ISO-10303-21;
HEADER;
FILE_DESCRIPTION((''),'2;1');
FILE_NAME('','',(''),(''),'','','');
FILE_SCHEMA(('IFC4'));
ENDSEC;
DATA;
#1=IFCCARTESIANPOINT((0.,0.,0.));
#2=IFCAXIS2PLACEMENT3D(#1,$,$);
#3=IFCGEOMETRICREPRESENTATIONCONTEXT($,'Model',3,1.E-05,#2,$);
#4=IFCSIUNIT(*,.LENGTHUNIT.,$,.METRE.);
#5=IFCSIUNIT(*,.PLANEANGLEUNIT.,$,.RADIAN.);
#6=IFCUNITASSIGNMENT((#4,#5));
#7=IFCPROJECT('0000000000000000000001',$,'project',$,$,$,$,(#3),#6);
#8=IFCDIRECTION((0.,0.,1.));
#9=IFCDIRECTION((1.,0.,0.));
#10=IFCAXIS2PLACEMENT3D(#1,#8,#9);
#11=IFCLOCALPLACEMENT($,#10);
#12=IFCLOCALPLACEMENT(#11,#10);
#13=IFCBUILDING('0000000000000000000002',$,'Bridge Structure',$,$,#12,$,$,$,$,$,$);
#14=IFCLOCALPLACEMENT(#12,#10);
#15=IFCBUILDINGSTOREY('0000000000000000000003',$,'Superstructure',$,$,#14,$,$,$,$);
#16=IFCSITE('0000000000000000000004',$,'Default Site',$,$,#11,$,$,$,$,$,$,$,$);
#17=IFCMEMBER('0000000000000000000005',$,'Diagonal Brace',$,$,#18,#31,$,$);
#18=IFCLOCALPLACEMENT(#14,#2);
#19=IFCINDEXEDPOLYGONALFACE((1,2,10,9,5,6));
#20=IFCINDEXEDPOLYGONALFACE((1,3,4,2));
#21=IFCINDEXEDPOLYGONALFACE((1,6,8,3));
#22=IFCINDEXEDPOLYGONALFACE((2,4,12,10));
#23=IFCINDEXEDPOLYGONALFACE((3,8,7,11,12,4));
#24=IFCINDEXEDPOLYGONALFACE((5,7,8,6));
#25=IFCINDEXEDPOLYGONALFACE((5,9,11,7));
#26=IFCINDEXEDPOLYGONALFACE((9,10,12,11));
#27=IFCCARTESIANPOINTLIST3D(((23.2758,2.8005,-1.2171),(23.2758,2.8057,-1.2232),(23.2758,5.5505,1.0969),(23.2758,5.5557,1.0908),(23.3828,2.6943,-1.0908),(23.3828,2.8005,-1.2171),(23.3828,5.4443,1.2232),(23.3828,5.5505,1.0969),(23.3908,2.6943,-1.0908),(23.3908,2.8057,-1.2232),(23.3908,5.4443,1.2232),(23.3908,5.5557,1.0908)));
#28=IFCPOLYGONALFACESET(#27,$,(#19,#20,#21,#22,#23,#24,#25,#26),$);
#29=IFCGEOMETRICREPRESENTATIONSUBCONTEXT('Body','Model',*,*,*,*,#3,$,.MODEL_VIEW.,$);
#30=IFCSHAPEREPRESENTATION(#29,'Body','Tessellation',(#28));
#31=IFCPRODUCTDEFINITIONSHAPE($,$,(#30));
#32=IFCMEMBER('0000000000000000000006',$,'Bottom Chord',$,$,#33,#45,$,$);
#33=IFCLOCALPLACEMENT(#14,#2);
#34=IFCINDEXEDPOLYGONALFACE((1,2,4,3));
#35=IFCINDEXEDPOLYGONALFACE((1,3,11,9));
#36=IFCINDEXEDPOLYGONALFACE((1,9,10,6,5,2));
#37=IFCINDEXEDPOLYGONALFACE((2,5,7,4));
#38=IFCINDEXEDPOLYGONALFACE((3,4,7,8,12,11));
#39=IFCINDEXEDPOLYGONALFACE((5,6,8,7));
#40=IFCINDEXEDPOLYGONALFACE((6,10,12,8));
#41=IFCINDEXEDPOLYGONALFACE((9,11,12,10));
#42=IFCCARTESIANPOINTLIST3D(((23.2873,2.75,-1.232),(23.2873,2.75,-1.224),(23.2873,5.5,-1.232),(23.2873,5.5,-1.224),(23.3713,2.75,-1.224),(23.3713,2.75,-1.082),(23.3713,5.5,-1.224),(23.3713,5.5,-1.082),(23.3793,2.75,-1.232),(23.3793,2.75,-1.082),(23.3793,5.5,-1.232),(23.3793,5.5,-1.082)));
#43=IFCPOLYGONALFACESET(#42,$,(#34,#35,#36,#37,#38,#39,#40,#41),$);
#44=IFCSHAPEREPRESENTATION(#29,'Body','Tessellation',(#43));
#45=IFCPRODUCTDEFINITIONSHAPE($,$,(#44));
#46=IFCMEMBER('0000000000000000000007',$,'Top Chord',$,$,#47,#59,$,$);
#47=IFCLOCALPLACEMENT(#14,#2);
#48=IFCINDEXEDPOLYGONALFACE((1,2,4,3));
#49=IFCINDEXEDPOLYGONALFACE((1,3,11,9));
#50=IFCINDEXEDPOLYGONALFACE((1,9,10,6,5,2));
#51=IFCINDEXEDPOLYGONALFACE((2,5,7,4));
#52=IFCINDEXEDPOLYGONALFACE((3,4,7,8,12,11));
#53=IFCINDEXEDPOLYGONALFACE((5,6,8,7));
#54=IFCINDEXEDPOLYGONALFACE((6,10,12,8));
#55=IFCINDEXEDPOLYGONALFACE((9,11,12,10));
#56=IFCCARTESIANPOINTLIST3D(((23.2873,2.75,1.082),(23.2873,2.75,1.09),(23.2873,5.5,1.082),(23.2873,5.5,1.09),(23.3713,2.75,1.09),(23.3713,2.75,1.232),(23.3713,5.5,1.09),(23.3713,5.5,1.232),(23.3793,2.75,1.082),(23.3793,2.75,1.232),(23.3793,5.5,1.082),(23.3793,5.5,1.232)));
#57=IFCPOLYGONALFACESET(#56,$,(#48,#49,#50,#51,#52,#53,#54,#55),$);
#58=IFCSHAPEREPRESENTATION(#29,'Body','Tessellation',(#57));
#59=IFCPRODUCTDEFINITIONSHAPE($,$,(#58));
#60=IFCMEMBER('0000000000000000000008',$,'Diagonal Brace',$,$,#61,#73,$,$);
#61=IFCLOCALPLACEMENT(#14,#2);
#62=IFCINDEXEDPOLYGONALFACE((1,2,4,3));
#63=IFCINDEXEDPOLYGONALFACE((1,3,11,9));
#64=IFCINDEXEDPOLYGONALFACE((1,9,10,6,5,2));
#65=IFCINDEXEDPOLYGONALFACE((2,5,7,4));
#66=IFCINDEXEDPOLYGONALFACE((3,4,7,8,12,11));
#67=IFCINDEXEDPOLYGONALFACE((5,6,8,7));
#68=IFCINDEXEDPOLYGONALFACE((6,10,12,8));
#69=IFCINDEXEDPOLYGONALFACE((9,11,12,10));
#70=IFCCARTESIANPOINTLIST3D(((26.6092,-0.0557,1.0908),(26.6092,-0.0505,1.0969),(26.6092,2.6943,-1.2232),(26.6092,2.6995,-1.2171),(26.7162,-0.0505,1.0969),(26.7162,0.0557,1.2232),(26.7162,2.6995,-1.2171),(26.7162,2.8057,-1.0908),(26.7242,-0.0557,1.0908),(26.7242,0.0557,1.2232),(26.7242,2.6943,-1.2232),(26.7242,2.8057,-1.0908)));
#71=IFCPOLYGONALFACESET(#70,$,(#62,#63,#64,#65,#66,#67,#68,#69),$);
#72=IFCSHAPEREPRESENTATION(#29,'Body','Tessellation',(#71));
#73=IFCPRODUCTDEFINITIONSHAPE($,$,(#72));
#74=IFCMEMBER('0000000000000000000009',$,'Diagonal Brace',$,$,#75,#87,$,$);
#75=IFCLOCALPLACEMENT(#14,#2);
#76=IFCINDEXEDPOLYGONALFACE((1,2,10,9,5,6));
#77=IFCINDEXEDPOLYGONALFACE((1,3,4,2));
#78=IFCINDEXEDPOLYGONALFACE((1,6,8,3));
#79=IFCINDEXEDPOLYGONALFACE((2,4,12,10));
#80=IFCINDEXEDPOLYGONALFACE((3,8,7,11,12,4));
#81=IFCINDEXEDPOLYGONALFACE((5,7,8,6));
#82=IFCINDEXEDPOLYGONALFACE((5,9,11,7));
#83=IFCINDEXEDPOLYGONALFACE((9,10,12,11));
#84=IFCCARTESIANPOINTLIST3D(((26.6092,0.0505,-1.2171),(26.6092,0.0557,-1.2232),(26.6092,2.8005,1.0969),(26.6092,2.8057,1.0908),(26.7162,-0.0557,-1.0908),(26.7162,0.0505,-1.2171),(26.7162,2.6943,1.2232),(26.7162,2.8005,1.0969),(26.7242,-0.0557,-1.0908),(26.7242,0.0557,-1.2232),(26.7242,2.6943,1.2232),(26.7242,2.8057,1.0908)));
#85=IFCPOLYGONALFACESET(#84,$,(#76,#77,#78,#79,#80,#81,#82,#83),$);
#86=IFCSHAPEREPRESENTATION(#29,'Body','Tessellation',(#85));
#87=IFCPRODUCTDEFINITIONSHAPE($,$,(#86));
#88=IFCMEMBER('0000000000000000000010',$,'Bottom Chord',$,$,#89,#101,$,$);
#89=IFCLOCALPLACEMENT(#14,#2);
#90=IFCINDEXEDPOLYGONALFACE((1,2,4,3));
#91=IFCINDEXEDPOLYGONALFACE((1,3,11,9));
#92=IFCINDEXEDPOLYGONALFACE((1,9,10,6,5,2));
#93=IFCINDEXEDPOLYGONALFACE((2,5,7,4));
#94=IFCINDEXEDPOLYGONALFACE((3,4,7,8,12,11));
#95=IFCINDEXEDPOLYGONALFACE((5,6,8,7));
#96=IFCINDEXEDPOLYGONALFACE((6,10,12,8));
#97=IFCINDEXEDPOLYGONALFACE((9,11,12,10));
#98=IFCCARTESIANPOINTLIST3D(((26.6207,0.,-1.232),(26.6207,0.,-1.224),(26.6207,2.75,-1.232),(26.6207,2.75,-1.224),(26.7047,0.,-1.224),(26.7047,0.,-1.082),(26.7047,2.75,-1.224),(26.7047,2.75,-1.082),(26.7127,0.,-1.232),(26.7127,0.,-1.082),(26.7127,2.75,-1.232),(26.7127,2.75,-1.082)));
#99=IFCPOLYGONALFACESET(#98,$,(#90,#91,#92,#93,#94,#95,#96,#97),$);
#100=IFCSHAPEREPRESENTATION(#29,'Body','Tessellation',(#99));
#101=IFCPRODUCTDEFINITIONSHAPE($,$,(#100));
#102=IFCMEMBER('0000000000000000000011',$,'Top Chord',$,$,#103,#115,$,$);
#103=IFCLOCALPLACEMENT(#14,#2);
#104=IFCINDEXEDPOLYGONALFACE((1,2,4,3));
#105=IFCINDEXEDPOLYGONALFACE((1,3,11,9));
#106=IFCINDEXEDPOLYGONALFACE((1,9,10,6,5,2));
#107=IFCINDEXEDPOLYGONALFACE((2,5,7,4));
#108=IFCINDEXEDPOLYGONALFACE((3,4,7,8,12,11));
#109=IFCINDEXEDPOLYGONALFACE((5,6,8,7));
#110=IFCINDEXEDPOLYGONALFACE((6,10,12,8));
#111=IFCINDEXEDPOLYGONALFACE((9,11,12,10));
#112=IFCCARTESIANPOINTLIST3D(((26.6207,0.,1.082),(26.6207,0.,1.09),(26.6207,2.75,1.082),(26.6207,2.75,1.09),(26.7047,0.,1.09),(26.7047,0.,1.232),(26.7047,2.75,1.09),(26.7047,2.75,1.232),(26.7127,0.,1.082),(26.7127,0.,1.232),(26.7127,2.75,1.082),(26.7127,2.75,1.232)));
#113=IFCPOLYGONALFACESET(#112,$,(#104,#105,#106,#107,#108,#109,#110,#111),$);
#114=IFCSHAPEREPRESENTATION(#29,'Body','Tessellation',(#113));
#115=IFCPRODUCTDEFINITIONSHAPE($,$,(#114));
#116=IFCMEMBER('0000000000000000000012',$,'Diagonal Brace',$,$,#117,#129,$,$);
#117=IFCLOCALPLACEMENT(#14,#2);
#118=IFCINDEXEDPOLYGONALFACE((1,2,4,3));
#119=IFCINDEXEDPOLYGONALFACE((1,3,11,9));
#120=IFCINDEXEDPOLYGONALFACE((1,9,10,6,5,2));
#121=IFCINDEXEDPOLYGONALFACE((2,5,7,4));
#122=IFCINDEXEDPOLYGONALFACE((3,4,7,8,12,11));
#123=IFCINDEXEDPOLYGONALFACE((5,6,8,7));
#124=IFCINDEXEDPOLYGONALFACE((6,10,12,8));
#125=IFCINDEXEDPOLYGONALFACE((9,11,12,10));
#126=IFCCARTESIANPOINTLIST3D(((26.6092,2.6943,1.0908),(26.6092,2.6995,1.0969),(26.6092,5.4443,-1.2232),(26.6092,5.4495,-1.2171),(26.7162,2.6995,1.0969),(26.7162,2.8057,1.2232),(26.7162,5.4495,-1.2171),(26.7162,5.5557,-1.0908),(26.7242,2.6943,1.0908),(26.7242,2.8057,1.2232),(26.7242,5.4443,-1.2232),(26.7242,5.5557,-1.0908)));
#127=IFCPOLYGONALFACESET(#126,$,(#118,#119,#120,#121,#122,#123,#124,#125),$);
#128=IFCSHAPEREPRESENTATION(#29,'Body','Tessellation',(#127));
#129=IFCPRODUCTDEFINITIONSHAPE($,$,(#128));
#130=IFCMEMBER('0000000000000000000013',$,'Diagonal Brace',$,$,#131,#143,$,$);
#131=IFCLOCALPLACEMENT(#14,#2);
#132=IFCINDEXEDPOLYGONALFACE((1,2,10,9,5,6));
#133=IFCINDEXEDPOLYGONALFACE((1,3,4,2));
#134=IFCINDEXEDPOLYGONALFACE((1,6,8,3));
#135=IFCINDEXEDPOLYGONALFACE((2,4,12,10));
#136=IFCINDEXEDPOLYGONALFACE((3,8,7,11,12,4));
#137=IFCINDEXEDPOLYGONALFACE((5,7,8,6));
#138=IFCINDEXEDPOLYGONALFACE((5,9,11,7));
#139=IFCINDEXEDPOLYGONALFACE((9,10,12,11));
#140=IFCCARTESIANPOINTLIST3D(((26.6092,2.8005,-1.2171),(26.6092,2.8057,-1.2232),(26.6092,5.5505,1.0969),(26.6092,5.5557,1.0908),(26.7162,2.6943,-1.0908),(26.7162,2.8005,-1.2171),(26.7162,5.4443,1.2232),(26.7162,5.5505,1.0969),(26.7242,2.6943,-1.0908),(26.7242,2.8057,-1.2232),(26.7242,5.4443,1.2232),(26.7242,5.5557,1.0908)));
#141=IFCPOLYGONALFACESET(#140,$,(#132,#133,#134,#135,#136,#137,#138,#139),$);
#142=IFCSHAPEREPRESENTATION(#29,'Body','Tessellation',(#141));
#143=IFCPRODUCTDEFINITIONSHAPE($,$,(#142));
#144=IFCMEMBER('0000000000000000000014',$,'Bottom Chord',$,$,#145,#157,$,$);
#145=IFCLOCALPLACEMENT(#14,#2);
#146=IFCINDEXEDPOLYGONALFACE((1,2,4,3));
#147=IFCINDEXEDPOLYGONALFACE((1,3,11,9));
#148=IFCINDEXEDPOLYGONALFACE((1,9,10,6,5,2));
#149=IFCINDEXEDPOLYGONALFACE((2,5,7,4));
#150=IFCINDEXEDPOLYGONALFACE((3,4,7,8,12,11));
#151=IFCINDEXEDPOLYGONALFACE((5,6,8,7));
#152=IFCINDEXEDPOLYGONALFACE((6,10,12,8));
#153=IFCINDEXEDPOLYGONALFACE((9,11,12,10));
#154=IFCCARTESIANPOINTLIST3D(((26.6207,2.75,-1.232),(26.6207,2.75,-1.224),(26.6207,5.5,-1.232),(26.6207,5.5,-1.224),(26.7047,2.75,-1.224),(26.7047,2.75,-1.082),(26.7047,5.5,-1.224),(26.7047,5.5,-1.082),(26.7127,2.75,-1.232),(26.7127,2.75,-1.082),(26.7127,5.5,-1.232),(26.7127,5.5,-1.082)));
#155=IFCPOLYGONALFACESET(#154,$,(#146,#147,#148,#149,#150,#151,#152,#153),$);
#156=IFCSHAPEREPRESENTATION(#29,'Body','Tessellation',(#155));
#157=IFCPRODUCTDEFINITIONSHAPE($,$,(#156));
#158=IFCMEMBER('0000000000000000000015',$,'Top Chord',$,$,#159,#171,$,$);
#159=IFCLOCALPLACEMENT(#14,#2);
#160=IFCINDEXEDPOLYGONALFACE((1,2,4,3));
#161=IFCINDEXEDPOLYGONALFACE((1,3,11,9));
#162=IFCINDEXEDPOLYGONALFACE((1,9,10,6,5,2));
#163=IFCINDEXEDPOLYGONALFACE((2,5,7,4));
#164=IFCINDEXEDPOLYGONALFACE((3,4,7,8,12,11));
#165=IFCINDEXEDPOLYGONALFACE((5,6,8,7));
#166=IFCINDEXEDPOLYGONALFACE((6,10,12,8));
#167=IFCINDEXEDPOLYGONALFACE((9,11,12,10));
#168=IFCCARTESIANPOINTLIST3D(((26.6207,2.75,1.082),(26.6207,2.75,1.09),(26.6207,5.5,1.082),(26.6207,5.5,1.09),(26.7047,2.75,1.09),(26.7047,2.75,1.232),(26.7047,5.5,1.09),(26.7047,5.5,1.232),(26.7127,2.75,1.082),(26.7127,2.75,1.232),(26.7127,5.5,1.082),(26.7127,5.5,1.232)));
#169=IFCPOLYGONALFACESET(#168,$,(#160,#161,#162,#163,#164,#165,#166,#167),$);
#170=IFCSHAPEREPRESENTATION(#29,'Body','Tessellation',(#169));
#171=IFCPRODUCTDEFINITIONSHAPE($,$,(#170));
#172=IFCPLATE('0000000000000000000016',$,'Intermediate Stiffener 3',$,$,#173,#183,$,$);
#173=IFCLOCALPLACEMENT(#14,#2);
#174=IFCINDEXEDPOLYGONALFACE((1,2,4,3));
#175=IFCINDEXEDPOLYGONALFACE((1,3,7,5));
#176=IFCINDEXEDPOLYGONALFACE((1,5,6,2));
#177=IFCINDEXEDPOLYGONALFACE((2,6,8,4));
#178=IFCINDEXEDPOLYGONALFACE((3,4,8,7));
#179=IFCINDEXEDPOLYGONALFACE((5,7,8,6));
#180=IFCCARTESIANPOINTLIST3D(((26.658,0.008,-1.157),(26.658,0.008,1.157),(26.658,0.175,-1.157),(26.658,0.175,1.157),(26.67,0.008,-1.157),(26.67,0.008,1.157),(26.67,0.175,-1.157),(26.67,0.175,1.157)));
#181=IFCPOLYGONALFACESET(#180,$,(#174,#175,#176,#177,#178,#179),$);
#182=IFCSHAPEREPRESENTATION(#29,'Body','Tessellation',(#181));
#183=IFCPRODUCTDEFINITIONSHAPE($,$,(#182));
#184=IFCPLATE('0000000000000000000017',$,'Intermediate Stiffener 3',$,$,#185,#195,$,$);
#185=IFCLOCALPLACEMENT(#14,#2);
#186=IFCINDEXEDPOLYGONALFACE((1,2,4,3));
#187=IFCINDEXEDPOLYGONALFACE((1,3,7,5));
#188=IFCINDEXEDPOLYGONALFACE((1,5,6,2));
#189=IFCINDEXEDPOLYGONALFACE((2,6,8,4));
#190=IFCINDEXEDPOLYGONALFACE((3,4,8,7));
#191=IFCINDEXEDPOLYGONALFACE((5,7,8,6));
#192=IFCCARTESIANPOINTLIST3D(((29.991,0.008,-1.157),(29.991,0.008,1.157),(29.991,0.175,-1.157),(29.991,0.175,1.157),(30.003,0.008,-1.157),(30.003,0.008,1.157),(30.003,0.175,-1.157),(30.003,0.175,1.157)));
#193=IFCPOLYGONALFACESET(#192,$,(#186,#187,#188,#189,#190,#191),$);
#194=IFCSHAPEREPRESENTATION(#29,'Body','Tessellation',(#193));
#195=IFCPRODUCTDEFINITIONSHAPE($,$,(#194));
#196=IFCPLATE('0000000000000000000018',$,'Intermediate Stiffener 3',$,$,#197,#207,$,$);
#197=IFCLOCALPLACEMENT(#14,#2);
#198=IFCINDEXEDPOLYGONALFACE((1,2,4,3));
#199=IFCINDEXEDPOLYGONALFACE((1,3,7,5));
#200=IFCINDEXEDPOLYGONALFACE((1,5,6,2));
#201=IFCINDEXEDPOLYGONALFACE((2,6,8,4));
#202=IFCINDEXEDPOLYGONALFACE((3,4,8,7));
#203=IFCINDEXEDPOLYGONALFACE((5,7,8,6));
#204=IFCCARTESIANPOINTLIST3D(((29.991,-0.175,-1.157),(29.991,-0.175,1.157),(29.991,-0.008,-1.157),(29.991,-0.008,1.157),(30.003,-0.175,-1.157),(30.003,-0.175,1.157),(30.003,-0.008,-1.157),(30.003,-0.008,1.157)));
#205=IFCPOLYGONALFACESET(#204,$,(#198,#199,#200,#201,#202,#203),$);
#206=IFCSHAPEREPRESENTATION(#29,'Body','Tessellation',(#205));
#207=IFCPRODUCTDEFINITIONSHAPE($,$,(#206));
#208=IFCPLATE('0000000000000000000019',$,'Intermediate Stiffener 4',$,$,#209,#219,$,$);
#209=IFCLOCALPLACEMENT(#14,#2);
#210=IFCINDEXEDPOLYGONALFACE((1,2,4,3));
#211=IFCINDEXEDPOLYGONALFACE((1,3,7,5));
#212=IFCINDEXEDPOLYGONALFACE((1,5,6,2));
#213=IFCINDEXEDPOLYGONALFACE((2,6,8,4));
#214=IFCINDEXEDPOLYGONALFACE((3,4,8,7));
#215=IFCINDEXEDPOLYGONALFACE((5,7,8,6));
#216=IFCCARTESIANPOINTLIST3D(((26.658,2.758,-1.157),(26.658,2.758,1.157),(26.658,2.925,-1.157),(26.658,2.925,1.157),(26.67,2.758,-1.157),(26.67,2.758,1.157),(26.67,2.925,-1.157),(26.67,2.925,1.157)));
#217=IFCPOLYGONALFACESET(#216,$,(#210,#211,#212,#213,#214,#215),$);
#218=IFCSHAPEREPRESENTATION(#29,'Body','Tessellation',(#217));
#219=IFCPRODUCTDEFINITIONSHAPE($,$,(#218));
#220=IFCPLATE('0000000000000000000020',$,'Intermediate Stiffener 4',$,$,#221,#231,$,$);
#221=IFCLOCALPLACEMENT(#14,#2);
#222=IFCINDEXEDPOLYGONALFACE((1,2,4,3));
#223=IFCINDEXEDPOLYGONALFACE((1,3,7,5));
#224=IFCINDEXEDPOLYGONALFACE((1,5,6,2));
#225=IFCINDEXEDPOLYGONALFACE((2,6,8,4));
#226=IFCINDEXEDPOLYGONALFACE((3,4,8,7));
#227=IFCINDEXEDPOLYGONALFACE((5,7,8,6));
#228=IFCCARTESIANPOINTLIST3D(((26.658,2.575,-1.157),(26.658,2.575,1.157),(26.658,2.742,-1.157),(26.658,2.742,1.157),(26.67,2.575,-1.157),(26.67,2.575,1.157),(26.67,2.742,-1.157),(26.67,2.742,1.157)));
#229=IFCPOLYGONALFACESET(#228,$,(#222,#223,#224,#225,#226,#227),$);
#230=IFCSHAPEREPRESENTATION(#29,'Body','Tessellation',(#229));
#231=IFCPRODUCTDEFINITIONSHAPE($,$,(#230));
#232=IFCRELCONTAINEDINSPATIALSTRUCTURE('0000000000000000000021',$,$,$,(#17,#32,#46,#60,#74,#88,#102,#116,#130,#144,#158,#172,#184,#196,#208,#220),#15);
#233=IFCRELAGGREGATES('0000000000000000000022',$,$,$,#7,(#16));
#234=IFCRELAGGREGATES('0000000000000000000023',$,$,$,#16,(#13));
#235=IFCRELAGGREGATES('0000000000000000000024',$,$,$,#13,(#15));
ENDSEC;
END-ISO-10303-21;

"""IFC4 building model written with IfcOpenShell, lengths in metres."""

from ifc_helpers import new_model, si_unit, frame, origin, origin_with_axes, origin_2d_with_axis, place, context, subcontext, project, spatial, rectangle, l_section, extrude, element, save


model = new_model("IFC4")

# Units and contexts
model_context = context("Model", 3, precision=1e-05, world=origin())
body_context = subcontext(model_context, "Body", "Model", "MODEL_VIEW")
ifc_project = project(units=[si_unit("LENGTHUNIT", "METRE"), si_unit("PLANEANGLEUNIT", "RADIAN")], contexts=[model_context])

# Site, building, storey
site_placement = place(None, origin_with_axes())
site = spatial("IfcSite", under=ifc_project, at=site_placement, Name="Default Site")
building_placement = place(site_placement, origin_with_axes())
building = spatial("IfcBuilding", under=site, at=building_placement, Name="Bridge Structure")
storey_placement = place(building_placement, origin_with_axes())
storey = spatial("IfcBuildingStorey", under=building, at=storey_placement, Name="Superstructure")

# Members
member_placement = place(storey_placement, frame((23.3333, 2.75, -1.157), z_axis=(0.0, 0.765156, 0.643844), x_axis=(-1.0, 0.0, 0.0)))
element("IfcMember", 1, at=member_placement, inside=storey, Name="Diagonal Brace", context=body_context, shape_type="SweptSolid", body=[
    extrude(l_section(Depth=0.173, Width=0.115, Thickness=0.008, at=origin_2d_with_axis()), origin_with_axes(), (0.0, 0.0, 1.0), 3.594),
])
for number, where, z_axis, x_axis, name in (
    (2, (23.3333, 2.75, -1.157), (0.0, 1.0, 0.0), (-1.0, 0.0, 0.0), "Bottom Chord"),
    (3, (23.3333, 2.75, 1.157), (0.0, 1.0, 0.0), (-1.0, 0.0, 0.0), "Top Chord"),
):
    element("IfcMember", number, at=place(storey_placement, frame(where, z_axis=z_axis, x_axis=x_axis)), inside=storey, Name=name, context=body_context, shape_type="SweptSolid", body=[
        extrude(l_section(Depth=0.15, Width=0.092, Thickness=0.008, at=origin_2d_with_axis()), origin_with_axes(), (0.0, 0.0, 1.0), 2.75),
    ])
for number, where, z_axis, x_axis, name in (
    (4, (26.6667, 0.0, 1.157), (0.0, 0.765156, -0.643844), (-1.0, 0.0, 0.0), "Diagonal Brace"),
    (5, (26.6667, 0.0, -1.157), (0.0, 0.765156, 0.643844), (-1.0, 0.0, 0.0), "Diagonal Brace"),
):
    element("IfcMember", number, at=place(storey_placement, frame(where, z_axis=z_axis, x_axis=x_axis)), inside=storey, Name=name, context=body_context, shape_type="SweptSolid", body=[
        extrude(l_section(Depth=0.173, Width=0.115, Thickness=0.008, at=origin_2d_with_axis()), origin_with_axes(), (0.0, 0.0, 1.0), 3.594),
    ])
for number, where, z_axis, x_axis, name in (
    (6, (26.6667, 0.0, -1.157), (0.0, 1.0, 0.0), (-1.0, 0.0, 0.0), "Bottom Chord"),
    (7, (26.6667, 0.0, 1.157), (0.0, 1.0, 0.0), (-1.0, 0.0, 0.0), "Top Chord"),
):
    element("IfcMember", number, at=place(storey_placement, frame(where, z_axis=z_axis, x_axis=x_axis)), inside=storey, Name=name, context=body_context, shape_type="SweptSolid", body=[
        extrude(l_section(Depth=0.15, Width=0.092, Thickness=0.008, at=origin_2d_with_axis()), origin_with_axes(), (0.0, 0.0, 1.0), 2.75),
    ])
for number, where, z_axis, x_axis, name in (
    (8, (26.6667, 2.75, 1.157), (0.0, 0.765156, -0.643844), (-1.0, 0.0, 0.0), "Diagonal Brace"),
    (9, (26.6667, 2.75, -1.157), (0.0, 0.765156, 0.643844), (-1.0, 0.0, 0.0), "Diagonal Brace"),
):
    element("IfcMember", number, at=place(storey_placement, frame(where, z_axis=z_axis, x_axis=x_axis)), inside=storey, Name=name, context=body_context, shape_type="SweptSolid", body=[
        extrude(l_section(Depth=0.173, Width=0.115, Thickness=0.008, at=origin_2d_with_axis()), origin_with_axes(), (0.0, 0.0, 1.0), 3.594),
    ])
for number, where, z_axis, x_axis, name in (
    (10, (26.6667, 2.75, -1.157), (0.0, 1.0, 0.0), (-1.0, 0.0, 0.0), "Bottom Chord"),
    (11, (26.6667, 2.75, 1.157), (0.0, 1.0, 0.0), (-1.0, 0.0, 0.0), "Top Chord"),
):
    element("IfcMember", number, at=place(storey_placement, frame(where, z_axis=z_axis, x_axis=x_axis)), inside=storey, Name=name, context=body_context, shape_type="SweptSolid", body=[
        extrude(l_section(Depth=0.15, Width=0.092, Thickness=0.008, at=origin_2d_with_axis()), origin_with_axes(), (0.0, 0.0, 1.0), 2.75),
    ])

# Plates
for number, where, z_axis, x_axis, name in (
    (12, (26.664, 0.0915, -1.157), (0.0, 0.0, 1.0), (1.0, 0.0, 0.0), "Intermediate Stiffener 3"),
    (13, (29.997, 0.0915, -1.157), (0.0, 0.0, 1.0), (1.0, 0.0, 0.0), "Intermediate Stiffener 3"),
    (14, (29.997, -0.0915, -1.157), (0.0, 0.0, 1.0), (1.0, 0.0, 0.0), "Intermediate Stiffener 3"),
    (15, (26.664, 2.8415, -1.157), (0.0, 0.0, 1.0), (1.0, 0.0, 0.0), "Intermediate Stiffener 4"),
    (16, (26.664, 2.6585, -1.157), (0.0, 0.0, 1.0), (1.0, 0.0, 0.0), "Intermediate Stiffener 4"),
):
    element("IfcPlate", number, at=place(storey_placement, frame(where, z_axis=z_axis, x_axis=x_axis)), inside=storey, Name=name, context=body_context, shape_type="SweptSolid", body=[
        extrude(rectangle(XDim=0.012, YDim=0.167, at=origin_2d_with_axis()), origin_with_axes(), (0.0, 0.0, 1.0), 2.314),
    ])

save(model, "model.ifc")
